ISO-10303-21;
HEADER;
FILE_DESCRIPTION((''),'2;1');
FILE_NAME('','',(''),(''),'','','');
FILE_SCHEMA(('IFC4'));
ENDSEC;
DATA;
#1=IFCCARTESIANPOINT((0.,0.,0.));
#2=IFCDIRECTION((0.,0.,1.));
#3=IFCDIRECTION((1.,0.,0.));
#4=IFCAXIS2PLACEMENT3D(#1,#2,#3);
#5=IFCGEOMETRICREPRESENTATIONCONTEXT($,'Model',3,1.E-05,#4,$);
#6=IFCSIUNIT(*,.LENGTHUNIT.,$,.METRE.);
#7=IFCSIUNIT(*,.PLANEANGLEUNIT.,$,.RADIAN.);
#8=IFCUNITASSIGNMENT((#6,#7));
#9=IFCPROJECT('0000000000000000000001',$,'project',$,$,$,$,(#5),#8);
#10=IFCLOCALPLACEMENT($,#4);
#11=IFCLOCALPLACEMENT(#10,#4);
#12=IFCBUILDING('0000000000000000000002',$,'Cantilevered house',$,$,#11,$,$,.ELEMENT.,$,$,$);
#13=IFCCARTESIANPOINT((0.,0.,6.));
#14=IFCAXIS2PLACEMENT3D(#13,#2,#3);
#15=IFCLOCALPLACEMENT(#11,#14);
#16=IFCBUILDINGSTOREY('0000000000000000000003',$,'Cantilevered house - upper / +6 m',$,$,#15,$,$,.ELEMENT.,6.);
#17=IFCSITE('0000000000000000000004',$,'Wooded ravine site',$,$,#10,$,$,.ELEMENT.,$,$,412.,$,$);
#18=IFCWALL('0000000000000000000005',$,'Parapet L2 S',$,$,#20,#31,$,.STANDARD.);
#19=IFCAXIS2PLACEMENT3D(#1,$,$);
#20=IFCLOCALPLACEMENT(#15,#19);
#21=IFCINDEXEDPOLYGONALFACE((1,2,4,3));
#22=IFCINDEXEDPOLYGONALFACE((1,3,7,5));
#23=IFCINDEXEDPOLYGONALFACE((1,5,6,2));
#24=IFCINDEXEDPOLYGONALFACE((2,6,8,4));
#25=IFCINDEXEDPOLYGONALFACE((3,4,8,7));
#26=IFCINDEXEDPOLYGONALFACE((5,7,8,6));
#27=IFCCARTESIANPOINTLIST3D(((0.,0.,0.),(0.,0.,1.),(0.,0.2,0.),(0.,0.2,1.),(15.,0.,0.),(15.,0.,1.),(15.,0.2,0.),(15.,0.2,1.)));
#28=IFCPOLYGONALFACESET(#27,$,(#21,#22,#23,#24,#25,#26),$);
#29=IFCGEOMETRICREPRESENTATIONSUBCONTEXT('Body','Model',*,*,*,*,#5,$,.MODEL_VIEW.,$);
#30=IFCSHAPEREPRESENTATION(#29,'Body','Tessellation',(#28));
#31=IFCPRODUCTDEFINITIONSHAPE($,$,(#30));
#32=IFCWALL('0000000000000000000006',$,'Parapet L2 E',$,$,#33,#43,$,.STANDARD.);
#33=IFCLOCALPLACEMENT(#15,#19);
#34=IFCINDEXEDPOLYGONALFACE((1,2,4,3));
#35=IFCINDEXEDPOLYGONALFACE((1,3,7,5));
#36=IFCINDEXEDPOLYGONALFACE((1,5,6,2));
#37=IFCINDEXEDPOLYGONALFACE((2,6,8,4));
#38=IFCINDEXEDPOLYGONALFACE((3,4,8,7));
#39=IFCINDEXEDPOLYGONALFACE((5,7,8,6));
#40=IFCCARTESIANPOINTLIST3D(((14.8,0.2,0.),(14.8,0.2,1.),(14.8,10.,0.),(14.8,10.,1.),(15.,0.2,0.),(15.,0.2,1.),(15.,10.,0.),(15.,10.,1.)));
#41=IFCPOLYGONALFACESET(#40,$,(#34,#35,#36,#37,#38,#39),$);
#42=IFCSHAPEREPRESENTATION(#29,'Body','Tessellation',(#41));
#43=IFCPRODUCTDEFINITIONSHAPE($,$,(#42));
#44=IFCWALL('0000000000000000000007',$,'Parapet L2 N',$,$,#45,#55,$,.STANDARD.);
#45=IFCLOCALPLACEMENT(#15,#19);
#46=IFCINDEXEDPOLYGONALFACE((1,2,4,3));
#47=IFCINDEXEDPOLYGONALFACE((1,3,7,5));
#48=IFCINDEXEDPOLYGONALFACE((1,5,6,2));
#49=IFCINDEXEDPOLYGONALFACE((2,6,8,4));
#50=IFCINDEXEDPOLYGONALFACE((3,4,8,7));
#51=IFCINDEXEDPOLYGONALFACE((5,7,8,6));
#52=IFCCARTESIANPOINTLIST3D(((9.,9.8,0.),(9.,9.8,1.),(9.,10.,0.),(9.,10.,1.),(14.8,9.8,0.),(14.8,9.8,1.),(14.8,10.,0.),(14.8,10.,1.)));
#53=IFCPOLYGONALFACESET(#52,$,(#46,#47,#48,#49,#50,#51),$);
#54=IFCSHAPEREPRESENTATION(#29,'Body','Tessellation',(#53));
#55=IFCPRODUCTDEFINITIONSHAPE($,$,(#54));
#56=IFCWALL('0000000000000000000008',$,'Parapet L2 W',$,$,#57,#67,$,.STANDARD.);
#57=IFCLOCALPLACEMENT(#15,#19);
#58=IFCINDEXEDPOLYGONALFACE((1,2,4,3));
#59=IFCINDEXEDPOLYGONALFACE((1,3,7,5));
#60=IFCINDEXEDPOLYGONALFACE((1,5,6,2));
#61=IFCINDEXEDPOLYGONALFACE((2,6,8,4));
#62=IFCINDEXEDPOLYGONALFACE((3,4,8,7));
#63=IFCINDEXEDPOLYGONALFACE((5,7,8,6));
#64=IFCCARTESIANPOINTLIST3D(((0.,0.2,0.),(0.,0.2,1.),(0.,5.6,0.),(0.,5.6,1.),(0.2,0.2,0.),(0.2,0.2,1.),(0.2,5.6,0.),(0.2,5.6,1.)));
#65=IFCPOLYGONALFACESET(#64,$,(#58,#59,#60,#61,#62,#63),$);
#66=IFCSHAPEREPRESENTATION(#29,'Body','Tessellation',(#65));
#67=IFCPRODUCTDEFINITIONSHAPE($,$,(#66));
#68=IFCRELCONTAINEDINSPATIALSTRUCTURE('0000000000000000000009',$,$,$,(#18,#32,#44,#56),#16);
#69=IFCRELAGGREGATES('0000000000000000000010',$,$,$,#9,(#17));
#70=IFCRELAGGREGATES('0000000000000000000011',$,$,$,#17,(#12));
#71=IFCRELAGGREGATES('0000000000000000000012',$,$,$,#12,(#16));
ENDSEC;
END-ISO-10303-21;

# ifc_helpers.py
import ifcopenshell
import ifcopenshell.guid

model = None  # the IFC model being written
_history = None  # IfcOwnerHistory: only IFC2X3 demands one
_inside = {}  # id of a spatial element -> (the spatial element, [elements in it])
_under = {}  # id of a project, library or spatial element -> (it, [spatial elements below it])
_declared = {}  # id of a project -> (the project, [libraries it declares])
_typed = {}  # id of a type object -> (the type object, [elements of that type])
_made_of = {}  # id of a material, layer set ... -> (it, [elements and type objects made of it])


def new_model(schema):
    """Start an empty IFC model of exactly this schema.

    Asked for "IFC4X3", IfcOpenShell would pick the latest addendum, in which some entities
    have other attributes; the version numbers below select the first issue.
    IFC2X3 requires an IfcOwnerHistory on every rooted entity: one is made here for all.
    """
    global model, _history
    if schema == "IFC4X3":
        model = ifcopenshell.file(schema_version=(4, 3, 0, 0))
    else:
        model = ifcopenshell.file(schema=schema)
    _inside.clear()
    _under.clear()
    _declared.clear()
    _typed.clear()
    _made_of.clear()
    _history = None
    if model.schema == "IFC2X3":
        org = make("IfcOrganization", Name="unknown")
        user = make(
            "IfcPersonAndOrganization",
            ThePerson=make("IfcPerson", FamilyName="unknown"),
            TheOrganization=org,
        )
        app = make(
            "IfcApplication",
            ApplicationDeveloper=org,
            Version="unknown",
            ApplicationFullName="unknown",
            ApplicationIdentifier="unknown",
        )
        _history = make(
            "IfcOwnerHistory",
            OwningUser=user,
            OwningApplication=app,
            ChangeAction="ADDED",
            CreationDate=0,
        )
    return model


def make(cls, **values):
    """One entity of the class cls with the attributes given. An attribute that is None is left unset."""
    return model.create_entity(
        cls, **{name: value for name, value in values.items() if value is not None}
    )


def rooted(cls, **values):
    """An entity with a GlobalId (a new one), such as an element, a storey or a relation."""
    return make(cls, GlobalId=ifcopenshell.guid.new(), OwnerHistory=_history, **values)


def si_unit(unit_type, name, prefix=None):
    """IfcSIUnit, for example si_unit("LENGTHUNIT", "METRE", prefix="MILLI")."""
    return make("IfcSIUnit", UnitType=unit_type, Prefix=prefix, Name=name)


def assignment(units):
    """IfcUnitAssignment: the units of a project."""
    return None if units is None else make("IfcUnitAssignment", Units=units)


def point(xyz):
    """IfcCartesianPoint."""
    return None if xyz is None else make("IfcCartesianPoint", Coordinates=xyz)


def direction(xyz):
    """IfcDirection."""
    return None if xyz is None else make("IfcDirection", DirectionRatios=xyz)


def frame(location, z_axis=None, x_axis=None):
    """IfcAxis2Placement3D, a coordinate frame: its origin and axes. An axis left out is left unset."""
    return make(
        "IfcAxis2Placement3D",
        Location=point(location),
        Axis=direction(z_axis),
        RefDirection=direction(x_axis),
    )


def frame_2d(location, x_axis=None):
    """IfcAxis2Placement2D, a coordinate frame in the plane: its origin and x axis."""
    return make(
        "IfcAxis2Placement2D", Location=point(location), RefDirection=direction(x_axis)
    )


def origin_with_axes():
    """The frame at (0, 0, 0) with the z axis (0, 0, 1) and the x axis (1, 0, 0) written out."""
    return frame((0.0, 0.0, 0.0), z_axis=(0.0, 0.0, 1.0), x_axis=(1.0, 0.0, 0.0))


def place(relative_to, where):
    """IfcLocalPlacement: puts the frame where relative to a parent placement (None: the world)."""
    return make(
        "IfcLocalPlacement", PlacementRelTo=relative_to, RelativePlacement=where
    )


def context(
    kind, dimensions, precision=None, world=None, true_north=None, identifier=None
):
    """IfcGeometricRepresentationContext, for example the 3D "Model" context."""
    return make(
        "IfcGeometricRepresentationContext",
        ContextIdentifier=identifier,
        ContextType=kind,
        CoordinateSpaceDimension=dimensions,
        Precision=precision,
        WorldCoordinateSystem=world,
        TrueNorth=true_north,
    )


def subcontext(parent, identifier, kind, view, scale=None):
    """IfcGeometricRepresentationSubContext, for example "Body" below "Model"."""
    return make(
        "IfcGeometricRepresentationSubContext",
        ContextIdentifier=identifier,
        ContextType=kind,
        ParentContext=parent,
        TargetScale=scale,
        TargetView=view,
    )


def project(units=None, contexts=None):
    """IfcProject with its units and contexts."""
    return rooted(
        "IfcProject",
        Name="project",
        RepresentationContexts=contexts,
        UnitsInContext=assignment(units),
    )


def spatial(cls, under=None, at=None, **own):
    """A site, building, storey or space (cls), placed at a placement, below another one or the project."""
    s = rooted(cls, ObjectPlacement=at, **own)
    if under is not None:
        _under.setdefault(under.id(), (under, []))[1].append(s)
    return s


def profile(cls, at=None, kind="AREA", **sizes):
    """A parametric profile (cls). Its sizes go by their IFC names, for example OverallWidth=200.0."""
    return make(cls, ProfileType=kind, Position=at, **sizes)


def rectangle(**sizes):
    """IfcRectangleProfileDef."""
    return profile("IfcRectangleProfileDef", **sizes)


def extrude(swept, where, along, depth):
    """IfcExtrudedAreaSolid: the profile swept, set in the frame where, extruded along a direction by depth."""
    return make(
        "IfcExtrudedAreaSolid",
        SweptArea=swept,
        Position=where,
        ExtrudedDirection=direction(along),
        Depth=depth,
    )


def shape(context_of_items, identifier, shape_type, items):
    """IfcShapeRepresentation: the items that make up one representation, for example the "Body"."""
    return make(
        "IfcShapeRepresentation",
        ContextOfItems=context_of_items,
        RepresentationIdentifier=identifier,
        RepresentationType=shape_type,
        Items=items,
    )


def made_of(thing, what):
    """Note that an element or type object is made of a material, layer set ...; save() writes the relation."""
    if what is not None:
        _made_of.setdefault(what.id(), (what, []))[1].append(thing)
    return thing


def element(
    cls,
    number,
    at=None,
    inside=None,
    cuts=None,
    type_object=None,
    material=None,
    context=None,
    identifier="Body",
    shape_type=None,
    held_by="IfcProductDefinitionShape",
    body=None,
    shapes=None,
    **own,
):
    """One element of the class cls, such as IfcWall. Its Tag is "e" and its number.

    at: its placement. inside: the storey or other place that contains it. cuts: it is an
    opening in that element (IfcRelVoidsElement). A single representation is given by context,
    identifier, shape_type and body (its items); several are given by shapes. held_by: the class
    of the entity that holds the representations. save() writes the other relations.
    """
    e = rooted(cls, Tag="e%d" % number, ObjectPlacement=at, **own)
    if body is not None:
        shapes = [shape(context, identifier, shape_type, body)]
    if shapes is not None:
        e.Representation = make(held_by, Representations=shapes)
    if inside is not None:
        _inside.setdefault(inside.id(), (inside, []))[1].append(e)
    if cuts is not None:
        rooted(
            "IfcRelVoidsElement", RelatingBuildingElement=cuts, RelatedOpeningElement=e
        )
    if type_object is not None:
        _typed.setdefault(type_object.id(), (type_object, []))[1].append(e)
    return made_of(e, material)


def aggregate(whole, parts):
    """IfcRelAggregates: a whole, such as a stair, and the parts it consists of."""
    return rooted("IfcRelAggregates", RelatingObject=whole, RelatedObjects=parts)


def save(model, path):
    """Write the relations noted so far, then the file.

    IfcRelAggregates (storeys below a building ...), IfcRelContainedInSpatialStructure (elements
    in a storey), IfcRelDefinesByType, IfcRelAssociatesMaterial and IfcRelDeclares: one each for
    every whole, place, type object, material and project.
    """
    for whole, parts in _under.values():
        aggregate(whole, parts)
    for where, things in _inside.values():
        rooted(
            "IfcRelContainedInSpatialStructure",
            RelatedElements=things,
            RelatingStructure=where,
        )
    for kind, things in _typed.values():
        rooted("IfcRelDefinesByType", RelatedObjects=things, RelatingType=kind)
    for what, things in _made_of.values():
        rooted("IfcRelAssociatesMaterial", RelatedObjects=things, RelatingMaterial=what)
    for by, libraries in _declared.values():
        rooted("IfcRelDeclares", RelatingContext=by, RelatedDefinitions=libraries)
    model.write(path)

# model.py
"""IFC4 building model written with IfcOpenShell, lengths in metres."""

from ifc_helpers import new_model, si_unit, frame, frame_2d, origin_with_axes, place, context, subcontext, project, spatial, rectangle, extrude, element, save


model = new_model("IFC4")

# Units and contexts
model_context = context("Model", 3, precision=1e-05, world=origin_with_axes())
body_context = subcontext(model_context, "Body", "Model", "MODEL_VIEW")
ifc_project = project(units=[si_unit("LENGTHUNIT", "METRE"), si_unit("PLANEANGLEUNIT", "RADIAN")], contexts=[model_context])

# Site, building, storey
site_placement = place(None, origin_with_axes())
site = spatial("IfcSite", under=ifc_project, at=site_placement, Name="Wooded ravine site", CompositionType="ELEMENT", RefElevation=412.0)
building_placement = place(site_placement, origin_with_axes())
building = spatial("IfcBuilding", under=site, at=building_placement, Name="Cantilevered house", CompositionType="ELEMENT")
storey_placement = place(building_placement, frame((0.0, 0.0, 6.0), z_axis=(0.0, 0.0, 1.0), x_axis=(1.0, 0.0, 0.0)))
storey = spatial("IfcBuildingStorey", under=building, at=storey_placement, Name="Cantilevered house - upper / +6 m", CompositionType="ELEMENT", Elevation=6.0)

# Walls
wall_1_placement = place(storey_placement, origin_with_axes())
element("IfcWall", 1, at=wall_1_placement, inside=storey, Name="Parapet L2 S", PredefinedType="STANDARD", context=body_context, shape_type="SweptSolid", body=[
    extrude(rectangle(XDim=15.0, YDim=0.2, at=frame_2d((7.5, 0.1))), origin_with_axes(), (0.0, 0.0, 1.0), 1.0),
])
wall_2_placement = place(storey_placement, origin_with_axes())
element("IfcWall", 2, at=wall_2_placement, inside=storey, Name="Parapet L2 E", PredefinedType="STANDARD", context=body_context, shape_type="SweptSolid", body=[
    extrude(rectangle(XDim=0.2, YDim=9.8, at=frame_2d((14.9, 5.1))), origin_with_axes(), (0.0, 0.0, 1.0), 1.0),
])
wall_3_placement = place(storey_placement, origin_with_axes())
element("IfcWall", 3, at=wall_3_placement, inside=storey, Name="Parapet L2 N", PredefinedType="STANDARD", context=body_context, shape_type="SweptSolid", body=[
    extrude(rectangle(XDim=5.8, YDim=0.2, at=frame_2d((11.9, 9.9))), origin_with_axes(), (0.0, 0.0, 1.0), 1.0),
])
wall_4_placement = place(storey_placement, origin_with_axes())
element("IfcWall", 4, at=wall_4_placement, inside=storey, Name="Parapet L2 W", PredefinedType="STANDARD", context=body_context, shape_type="SweptSolid", body=[
    extrude(rectangle(XDim=0.2, YDim=5.4, at=frame_2d((0.1, 2.9))), origin_with_axes(), (0.0, 0.0, 1.0), 1.0),
])

save(model, "model.ifc")
